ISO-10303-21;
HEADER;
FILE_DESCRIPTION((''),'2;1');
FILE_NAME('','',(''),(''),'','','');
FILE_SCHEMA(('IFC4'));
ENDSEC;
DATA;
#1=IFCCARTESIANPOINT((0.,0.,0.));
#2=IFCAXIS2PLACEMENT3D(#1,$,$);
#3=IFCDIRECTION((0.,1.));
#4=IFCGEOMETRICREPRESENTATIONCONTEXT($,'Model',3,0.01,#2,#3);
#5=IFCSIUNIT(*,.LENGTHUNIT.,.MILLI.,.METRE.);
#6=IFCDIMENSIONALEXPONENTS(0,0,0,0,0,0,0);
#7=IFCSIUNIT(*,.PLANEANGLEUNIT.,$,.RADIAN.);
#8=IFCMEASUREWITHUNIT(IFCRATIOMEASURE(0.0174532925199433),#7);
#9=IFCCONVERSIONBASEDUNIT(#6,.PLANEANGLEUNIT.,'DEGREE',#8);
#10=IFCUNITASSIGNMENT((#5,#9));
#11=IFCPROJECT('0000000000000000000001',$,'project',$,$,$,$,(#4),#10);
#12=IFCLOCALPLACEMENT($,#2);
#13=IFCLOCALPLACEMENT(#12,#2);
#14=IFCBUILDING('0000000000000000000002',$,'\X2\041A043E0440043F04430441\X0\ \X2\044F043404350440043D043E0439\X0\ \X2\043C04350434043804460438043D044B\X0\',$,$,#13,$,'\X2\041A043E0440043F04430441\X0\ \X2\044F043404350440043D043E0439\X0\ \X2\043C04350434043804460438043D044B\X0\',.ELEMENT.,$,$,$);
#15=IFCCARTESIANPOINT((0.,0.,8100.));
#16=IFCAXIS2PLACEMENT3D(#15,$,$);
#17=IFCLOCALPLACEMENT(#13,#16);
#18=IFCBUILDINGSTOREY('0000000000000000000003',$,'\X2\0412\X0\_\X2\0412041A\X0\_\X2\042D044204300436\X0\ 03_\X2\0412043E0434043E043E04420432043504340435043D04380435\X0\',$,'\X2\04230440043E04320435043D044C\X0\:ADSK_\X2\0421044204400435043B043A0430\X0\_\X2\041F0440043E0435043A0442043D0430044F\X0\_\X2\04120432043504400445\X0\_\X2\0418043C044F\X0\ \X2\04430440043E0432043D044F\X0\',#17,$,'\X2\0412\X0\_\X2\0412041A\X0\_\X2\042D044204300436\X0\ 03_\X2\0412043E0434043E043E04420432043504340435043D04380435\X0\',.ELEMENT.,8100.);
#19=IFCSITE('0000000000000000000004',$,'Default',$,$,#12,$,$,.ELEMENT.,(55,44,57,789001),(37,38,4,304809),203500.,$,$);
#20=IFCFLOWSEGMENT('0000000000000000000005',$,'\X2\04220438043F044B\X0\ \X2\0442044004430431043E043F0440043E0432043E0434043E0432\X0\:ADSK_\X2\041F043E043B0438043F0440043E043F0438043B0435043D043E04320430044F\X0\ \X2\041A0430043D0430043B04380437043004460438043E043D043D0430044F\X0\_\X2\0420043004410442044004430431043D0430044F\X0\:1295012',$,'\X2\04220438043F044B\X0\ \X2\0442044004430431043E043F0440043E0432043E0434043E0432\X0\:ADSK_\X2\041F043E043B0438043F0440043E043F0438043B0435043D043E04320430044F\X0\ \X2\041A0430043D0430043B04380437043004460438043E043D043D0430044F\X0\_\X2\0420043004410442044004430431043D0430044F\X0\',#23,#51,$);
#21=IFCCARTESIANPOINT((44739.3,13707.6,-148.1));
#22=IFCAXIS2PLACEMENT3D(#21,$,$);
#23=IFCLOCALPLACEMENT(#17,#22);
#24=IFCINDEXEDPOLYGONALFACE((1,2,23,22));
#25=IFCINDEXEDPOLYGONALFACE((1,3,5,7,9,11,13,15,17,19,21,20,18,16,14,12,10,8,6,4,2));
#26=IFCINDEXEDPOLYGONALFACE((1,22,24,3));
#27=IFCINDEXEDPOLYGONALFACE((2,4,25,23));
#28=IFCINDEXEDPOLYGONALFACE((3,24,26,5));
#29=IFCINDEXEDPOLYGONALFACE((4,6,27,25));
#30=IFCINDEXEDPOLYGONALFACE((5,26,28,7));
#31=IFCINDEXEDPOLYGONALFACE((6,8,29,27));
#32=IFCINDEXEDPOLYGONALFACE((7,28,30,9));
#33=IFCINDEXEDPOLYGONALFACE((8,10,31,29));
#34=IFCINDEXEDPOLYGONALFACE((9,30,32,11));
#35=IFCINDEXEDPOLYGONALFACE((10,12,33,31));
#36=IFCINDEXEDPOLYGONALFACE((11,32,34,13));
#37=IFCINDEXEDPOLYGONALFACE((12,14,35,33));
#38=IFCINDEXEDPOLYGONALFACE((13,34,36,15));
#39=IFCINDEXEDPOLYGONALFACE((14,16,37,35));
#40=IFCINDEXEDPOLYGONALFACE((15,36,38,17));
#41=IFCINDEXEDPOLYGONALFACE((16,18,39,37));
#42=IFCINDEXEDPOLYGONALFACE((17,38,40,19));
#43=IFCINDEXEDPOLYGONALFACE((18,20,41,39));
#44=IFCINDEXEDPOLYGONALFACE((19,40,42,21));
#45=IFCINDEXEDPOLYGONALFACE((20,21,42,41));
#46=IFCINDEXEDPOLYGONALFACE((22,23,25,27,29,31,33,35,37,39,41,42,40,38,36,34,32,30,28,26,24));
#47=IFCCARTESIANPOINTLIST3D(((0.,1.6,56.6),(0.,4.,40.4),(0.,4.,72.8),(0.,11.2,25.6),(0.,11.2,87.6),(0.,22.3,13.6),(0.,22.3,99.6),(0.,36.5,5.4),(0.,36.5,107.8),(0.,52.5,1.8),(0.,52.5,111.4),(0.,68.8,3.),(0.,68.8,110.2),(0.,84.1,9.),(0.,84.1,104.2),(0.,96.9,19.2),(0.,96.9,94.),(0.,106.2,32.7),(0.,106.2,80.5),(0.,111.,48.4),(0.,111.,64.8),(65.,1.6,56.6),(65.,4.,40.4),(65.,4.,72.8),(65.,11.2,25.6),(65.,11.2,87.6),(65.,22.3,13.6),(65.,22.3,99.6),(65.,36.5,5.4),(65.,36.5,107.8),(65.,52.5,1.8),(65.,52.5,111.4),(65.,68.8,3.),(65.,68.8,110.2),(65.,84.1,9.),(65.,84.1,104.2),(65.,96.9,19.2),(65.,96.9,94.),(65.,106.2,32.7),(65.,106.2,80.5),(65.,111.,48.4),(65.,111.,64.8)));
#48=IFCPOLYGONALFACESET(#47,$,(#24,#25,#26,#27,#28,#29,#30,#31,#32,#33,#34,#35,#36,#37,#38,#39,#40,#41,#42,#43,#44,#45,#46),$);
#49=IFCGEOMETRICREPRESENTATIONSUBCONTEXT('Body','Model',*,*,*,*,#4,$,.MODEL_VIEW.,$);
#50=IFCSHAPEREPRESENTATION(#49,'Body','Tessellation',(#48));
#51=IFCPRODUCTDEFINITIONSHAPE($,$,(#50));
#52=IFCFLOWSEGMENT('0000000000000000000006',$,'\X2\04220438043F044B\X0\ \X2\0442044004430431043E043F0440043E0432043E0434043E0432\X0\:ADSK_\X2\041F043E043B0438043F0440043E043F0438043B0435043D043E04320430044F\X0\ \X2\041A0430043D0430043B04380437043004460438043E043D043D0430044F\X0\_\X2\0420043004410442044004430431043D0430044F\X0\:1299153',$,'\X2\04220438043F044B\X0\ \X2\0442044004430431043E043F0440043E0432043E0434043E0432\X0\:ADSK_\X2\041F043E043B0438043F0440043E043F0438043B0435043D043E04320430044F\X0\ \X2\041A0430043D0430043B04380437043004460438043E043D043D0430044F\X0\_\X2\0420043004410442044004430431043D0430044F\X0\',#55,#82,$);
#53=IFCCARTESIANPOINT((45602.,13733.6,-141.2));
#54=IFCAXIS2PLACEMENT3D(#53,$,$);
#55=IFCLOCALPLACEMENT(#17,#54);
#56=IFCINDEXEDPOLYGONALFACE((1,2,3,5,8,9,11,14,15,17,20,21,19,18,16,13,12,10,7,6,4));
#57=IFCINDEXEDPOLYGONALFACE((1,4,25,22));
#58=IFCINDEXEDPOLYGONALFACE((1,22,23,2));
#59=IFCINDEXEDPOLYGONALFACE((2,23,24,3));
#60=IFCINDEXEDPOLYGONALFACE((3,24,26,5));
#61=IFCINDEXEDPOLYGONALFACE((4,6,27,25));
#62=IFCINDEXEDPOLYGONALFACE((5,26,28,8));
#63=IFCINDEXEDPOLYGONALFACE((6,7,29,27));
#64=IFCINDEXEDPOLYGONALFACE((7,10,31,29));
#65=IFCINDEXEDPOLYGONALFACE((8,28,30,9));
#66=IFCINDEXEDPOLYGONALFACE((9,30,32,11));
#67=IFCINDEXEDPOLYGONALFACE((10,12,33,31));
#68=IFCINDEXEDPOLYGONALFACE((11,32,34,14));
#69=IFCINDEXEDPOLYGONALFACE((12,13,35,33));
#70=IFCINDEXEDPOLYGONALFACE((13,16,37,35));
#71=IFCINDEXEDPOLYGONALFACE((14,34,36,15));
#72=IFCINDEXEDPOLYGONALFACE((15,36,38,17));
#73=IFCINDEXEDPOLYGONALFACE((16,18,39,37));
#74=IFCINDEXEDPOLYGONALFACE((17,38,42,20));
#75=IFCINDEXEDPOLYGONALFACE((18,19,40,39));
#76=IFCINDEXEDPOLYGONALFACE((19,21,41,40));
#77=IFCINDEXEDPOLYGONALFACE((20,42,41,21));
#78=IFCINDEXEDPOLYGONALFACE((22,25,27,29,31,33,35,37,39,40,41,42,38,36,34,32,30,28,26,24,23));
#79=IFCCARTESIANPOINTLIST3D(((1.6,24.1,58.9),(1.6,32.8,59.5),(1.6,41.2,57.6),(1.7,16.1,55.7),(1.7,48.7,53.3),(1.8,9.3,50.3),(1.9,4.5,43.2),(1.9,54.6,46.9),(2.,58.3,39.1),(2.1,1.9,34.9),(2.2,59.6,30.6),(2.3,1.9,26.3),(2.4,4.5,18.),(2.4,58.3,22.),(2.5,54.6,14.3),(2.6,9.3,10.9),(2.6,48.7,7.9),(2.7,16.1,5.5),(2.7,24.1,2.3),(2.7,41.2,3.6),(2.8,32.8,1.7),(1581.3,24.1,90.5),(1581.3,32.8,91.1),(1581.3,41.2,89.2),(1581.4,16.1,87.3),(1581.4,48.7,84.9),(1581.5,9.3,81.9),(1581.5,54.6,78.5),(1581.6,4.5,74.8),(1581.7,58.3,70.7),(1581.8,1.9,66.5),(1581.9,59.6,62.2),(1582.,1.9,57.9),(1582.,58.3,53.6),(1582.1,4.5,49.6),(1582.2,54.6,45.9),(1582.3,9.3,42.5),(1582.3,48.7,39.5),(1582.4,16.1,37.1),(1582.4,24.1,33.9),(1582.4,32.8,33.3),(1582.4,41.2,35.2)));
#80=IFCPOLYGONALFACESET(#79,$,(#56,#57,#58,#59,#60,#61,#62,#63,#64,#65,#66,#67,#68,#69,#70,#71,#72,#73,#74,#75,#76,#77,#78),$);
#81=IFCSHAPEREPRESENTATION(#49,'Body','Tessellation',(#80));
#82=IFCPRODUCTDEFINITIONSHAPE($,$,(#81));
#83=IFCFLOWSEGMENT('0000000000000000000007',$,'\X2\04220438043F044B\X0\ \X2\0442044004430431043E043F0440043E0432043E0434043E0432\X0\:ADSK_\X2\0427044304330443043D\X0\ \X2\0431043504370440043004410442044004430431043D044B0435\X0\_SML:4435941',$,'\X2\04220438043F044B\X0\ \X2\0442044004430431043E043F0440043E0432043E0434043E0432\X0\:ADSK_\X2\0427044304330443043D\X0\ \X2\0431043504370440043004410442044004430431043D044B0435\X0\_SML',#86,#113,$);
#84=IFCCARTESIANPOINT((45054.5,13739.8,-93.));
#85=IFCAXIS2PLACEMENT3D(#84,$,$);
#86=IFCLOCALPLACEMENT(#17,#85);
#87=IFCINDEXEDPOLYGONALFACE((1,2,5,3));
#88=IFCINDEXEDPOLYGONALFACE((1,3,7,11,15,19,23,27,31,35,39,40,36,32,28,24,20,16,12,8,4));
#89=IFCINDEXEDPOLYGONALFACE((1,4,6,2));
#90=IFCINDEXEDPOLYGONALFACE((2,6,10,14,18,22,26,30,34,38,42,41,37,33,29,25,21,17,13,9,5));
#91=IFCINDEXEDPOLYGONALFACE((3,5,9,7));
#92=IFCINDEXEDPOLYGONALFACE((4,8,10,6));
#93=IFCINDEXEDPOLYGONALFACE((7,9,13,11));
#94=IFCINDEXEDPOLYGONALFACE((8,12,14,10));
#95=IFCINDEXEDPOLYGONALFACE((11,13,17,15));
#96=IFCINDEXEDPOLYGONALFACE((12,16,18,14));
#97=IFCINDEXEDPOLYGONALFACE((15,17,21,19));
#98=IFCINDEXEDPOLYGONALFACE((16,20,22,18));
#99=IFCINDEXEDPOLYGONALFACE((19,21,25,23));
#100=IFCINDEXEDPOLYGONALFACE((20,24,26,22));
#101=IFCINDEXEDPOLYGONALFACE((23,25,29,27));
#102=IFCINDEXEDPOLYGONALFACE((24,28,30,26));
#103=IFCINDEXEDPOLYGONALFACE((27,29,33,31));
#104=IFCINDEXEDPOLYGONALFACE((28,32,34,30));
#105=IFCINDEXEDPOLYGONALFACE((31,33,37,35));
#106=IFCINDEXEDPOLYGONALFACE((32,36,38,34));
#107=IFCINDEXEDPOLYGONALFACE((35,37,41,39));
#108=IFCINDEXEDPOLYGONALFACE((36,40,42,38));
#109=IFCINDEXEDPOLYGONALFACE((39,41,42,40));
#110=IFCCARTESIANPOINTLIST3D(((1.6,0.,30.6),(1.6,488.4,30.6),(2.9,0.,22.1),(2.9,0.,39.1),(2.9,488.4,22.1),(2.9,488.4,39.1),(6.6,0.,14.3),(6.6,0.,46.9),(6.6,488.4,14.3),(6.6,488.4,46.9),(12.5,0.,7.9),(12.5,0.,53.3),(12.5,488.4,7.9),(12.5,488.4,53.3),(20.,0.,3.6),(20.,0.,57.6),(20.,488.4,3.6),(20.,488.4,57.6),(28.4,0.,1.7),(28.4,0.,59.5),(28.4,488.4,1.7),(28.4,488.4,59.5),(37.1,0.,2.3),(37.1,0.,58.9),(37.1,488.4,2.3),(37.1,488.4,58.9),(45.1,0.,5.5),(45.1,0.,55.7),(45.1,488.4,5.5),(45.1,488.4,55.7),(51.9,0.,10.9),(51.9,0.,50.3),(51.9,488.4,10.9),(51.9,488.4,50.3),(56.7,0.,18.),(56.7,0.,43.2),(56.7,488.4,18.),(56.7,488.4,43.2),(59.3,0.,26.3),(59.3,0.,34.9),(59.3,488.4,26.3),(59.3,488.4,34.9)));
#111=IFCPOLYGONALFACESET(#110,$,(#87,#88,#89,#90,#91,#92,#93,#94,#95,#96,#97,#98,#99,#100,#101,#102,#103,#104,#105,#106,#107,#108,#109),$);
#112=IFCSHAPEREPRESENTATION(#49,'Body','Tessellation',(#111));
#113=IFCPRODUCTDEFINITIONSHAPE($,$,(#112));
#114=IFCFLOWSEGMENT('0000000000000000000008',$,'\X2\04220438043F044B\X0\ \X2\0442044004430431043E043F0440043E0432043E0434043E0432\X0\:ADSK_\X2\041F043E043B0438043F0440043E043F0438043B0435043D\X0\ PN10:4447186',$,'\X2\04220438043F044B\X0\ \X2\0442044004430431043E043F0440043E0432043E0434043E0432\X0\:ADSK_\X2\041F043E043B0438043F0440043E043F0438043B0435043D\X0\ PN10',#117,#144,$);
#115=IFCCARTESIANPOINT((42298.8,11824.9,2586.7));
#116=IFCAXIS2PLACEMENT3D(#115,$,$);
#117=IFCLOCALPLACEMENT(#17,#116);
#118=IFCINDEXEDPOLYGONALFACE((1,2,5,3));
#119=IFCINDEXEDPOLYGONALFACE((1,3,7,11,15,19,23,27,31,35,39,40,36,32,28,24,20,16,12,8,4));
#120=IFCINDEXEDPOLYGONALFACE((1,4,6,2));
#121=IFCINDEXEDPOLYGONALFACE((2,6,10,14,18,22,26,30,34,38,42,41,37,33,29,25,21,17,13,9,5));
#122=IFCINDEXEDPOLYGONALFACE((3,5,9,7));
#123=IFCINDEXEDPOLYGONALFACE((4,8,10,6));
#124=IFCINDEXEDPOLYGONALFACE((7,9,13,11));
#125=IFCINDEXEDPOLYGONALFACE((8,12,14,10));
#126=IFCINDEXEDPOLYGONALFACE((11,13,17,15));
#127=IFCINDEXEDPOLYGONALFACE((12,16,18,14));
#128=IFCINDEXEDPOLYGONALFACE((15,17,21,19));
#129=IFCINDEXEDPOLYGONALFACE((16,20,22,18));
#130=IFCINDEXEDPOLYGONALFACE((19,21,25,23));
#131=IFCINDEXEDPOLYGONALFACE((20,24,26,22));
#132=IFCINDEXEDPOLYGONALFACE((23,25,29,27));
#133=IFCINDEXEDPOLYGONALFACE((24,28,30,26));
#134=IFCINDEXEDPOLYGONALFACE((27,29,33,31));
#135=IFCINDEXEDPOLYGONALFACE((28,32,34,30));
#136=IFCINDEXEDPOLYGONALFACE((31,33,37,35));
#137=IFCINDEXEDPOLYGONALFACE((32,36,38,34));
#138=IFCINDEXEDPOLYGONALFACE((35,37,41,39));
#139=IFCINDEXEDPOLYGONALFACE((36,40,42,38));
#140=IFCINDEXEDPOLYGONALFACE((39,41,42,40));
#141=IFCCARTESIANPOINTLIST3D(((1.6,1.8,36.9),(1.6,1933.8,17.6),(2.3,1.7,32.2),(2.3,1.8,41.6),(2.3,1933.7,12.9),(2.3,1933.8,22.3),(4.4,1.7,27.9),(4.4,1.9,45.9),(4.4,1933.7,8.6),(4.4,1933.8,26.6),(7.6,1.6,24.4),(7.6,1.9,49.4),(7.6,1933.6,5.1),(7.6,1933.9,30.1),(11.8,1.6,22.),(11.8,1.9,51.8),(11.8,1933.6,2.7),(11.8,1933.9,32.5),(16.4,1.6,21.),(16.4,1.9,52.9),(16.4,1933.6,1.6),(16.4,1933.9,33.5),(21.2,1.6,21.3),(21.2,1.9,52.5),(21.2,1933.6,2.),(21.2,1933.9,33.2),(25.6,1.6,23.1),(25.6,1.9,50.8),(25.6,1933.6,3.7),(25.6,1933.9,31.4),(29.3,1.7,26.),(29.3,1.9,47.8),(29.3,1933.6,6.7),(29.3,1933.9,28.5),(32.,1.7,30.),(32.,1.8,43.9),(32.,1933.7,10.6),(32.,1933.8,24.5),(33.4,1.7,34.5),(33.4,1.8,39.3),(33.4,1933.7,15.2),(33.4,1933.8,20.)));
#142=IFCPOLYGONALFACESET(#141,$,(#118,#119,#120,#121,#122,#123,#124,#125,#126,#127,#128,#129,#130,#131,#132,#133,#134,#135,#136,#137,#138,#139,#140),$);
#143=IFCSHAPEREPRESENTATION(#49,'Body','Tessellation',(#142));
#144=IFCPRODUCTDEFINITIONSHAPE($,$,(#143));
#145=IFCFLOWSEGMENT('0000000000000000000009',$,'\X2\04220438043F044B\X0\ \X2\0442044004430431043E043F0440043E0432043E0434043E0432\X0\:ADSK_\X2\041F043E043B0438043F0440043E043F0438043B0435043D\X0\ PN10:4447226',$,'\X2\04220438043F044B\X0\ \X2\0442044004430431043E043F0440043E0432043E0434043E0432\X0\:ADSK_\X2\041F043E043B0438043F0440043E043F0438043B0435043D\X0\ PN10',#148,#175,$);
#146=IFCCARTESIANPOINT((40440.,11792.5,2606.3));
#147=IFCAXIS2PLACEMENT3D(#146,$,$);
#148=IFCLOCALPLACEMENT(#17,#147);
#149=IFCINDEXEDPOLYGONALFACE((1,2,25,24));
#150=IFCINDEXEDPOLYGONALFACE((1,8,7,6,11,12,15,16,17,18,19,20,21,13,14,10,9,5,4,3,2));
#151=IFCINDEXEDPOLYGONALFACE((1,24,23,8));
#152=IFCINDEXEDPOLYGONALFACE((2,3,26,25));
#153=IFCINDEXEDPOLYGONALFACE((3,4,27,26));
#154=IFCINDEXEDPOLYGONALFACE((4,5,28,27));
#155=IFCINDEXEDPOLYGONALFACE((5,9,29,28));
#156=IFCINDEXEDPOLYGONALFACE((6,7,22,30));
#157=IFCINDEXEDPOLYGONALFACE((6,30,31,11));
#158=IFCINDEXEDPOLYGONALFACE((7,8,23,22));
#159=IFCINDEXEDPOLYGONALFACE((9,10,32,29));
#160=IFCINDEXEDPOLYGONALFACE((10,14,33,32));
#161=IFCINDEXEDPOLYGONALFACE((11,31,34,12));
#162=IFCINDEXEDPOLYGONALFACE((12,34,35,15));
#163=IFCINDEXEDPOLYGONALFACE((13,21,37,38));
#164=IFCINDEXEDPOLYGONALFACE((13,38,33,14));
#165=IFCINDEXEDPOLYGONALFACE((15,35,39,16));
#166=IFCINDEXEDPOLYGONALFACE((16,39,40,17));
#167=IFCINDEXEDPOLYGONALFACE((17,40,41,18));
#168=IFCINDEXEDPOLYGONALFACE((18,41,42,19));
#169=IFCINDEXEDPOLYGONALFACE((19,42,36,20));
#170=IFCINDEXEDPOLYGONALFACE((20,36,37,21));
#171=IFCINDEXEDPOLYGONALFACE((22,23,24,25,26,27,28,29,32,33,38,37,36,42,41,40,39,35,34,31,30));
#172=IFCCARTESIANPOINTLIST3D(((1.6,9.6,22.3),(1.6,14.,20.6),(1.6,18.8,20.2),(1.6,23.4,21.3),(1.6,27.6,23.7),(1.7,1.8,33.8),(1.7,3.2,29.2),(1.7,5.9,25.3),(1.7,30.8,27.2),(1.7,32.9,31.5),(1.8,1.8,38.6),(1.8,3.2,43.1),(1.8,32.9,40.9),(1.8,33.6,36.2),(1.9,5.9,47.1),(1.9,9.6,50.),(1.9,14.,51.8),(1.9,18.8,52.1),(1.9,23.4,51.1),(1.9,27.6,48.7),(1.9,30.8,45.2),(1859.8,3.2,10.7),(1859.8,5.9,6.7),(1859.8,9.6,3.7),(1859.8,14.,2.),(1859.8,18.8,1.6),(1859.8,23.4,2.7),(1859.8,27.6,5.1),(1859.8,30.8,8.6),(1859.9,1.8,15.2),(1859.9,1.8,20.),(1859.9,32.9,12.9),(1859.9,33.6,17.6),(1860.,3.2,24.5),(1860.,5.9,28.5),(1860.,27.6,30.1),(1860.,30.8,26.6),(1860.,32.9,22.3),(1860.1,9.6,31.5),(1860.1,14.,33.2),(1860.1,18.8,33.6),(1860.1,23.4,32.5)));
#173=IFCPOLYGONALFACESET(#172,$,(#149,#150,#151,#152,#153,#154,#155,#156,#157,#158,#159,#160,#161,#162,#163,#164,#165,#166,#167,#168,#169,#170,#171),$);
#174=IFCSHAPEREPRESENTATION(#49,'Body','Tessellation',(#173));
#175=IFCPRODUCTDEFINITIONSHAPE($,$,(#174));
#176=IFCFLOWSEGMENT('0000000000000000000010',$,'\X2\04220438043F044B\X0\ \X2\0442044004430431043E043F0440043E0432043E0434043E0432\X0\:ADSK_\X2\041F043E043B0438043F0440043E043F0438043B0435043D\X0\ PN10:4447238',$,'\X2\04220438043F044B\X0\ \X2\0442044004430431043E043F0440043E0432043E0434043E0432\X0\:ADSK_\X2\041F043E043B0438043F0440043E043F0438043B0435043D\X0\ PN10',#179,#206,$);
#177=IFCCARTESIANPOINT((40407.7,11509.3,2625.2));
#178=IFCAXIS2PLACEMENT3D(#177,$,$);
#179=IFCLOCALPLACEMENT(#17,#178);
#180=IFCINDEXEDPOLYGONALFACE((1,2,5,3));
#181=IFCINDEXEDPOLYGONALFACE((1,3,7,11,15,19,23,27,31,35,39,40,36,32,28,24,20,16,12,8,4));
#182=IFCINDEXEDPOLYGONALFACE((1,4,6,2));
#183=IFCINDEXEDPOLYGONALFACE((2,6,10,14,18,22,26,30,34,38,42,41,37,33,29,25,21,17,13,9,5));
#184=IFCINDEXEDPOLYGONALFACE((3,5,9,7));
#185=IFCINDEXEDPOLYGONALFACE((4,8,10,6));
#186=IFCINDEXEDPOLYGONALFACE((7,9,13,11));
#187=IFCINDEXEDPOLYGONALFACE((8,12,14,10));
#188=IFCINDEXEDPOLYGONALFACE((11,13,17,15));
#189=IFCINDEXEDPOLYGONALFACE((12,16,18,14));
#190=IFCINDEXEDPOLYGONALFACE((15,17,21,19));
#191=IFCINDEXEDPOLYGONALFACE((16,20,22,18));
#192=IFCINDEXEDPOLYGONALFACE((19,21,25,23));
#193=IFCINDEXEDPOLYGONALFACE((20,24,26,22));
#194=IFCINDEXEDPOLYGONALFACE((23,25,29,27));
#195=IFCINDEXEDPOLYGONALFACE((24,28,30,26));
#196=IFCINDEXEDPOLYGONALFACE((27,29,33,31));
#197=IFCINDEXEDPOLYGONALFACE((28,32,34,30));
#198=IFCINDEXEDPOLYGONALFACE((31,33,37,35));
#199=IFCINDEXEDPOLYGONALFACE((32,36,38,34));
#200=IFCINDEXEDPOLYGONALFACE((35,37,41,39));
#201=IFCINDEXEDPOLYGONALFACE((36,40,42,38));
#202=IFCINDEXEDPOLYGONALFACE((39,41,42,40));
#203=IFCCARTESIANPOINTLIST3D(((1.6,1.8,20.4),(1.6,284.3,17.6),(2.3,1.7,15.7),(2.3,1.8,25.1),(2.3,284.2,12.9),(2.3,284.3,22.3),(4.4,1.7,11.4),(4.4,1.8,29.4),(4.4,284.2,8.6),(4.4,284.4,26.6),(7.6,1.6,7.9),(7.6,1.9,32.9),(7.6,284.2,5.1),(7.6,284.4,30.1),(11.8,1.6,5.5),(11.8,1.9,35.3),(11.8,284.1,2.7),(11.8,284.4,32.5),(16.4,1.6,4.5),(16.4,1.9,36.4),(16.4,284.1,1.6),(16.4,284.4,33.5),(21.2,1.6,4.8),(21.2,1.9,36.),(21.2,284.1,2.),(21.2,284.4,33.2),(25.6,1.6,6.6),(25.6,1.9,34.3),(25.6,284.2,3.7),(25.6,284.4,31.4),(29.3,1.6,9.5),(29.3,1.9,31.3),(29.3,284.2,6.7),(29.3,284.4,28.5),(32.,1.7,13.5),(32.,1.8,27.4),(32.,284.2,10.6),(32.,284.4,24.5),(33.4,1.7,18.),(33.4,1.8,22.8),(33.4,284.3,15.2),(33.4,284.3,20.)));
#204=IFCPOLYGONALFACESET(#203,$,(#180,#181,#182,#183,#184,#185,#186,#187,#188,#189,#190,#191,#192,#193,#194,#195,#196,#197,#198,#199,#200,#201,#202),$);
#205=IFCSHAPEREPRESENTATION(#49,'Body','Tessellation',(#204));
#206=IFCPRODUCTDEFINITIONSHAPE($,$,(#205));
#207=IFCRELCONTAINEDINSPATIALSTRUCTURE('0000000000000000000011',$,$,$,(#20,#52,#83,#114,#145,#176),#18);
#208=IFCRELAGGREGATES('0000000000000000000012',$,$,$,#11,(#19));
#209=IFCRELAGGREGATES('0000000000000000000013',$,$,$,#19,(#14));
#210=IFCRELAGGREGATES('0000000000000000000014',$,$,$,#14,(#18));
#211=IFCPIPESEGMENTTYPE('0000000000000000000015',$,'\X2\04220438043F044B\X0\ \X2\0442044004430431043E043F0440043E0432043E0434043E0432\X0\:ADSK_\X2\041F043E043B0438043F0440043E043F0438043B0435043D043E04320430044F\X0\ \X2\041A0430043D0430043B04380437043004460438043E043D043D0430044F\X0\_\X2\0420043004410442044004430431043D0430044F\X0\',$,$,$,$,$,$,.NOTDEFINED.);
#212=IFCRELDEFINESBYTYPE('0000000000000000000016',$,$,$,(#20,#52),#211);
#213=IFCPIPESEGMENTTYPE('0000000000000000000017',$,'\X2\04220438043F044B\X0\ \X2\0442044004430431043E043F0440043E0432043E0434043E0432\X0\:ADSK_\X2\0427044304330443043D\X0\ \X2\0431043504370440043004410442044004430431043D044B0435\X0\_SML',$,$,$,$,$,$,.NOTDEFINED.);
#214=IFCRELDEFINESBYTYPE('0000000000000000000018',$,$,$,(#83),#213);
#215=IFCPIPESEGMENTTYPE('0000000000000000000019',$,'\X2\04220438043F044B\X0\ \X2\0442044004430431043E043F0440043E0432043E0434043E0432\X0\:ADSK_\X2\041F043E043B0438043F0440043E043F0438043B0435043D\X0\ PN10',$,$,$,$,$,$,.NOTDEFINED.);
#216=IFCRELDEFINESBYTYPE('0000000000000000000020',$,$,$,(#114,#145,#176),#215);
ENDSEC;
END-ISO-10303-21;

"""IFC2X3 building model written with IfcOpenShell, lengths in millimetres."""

from ifc_helpers import new_model, entity, si_unit, converted_unit, direction, frame, origin, origin_2d_with_axis, place, context, subcontext, project, spatial, circle, extrude, type_object, element, save


model = new_model("IFC2X3")

# Units and contexts
model_context = context("Model", 3, precision=0.01, world=origin(), true_north=direction((0.0, 1.0)))
body_context = subcontext(model_context, "Body", "Model", "MODEL_VIEW")
ifc_project = project(units=[si_unit("LENGTHUNIT", "METRE", prefix="MILLI"), converted_unit("PLANEANGLEUNIT", "DEGREE", entity("IfcRatioMeasure", 0.0174532925199433), si_unit("PLANEANGLEUNIT", "RADIAN"), dimensions=[0, 0, 0, 0, 0, 0, 0])], contexts=[model_context])

# Site, building, storey
site_placement = place(None, origin())
site = spatial("IfcSite", under=ifc_project, at=site_placement, Name="Default", CompositionType="ELEMENT", RefLatitude=(55, 44, 57, 789001), RefLongitude=(37, 38, 4, 304809), RefElevation=203500.0)
building_placement = place(site_placement, origin())
building = spatial("IfcBuilding", under=site, at=building_placement, Name="Корпус ядерной медицины", LongName="Корпус ядерной медицины", CompositionType="ELEMENT")
storey_placement = place(building_placement, frame((0.0, 0.0, 8100.0)))
storey = spatial("IfcBuildingStorey", under=building, at=storey_placement, Name="В_ВК_Этаж 03_Водоотведение", ObjectType="Уровень:ADSK_Стрелка_Проектная_Вверх_Имя уровня", LongName="В_ВК_Этаж 03_Водоотведение", CompositionType="ELEMENT", Elevation=8100.0)

# Flow segments
pipe_segment_type_1 = type_object("IfcPipeSegmentType", Name="Типы трубопроводов:ADSK_Полипропиленовая Канализационная_Раструбная", PredefinedType="NOTDEFINED")
flow_segment_1_placement = place(storey_placement, frame((44739.3, 13707.6, -148.1)))
element("IfcFlowSegment", 1, at=flow_segment_1_placement, inside=storey, type_object=pipe_segment_type_1, Name="Типы трубопроводов:ADSK_Полипропиленовая Канализационная_Раструбная:1295012", ObjectType="Типы трубопроводов:ADSK_Полипропиленовая Канализационная_Раструбная", context=body_context, shape_type="SweptSolid", body=[
    extrude(circle(Radius=55.0, at=origin_2d_with_axis()), frame((0.0, 56.6, 56.6), z_axis=(1.0, 0.0, 0.0), x_axis=(0.0, -1.0, 0.0)), (0.0, 0.0, 1.0), 65.0),
])
flow_segment_2_placement = place(storey_placement, frame((45602.0, 13733.6, -141.2)))
element("IfcFlowSegment", 2, at=flow_segment_2_placement, inside=storey, type_object=pipe_segment_type_1, Name="Типы трубопроводов:ADSK_Полипропиленовая Канализационная_Раструбная:1299153", ObjectType="Типы трубопроводов:ADSK_Полипропиленовая Канализационная_Раструбная", context=body_context, shape_type="SweptSolid", body=[
    extrude(circle(Radius=29.0, at=origin_2d_with_axis()), frame((2.2, 30.6, 30.6), z_axis=(0.9998, 0.0, 0.019996), x_axis=(0.0, 1.0, 0.0)), (0.0, 0.0, 1.0), 1580.0),
])
pipe_segment_type_2 = type_object("IfcPipeSegmentType", Name="Типы трубопроводов:ADSK_Чугун безраструбные_SML", PredefinedType="NOTDEFINED")
flow_segment_3_placement = place(storey_placement, frame((45054.5, 13739.8, -93.0)))
element("IfcFlowSegment", 3, at=flow_segment_3_placement, inside=storey, type_object=pipe_segment_type_2, Name="Типы трубопроводов:ADSK_Чугун безраструбные_SML:4435941", ObjectType="Типы трубопроводов:ADSK_Чугун безраструбные_SML", context=body_context, shape_type="SweptSolid", body=[
    extrude(circle(Radius=29.0, at=origin_2d_with_axis()), frame((30.6, 0.0, 30.6), z_axis=(0.0, 1.0, 0.0), x_axis=(-1.0, 0.0, 0.0)), (0.0, 0.0, 1.0), 488.4),
])
pipe_segment_type_3 = type_object("IfcPipeSegmentType", Name="Типы трубопроводов:ADSK_Полипропилен PN10", PredefinedType="NOTDEFINED")
flow_segment_4_placement = place(storey_placement, frame((42298.8, 11824.9, 2586.7)))
element("IfcFlowSegment", 4, at=flow_segment_4_placement, inside=storey, type_object=pipe_segment_type_3, Name="Типы трубопроводов:ADSK_Полипропилен PN10:4447186", ObjectType="Типы трубопроводов:ADSK_Полипропилен PN10", context=body_context, shape_type="SweptSolid", body=[
    extrude(circle(Radius=16.0, at=origin_2d_with_axis()), frame((17.6, 1.8, 36.9), z_axis=(0.0, 0.99995, -0.01), x_axis=(-1.0, 0.0, 0.0)), (0.0, 0.0, 1.0), 1932.1),
])
flow_segment_5_placement = place(storey_placement, frame((40440.0, 11792.5, 2606.3)))
element("IfcFlowSegment", 5, at=flow_segment_5_placement, inside=storey, type_object=pipe_segment_type_3, Name="Типы трубопроводов:ADSK_Полипропилен PN10:4447226", ObjectType="Типы трубопроводов:ADSK_Полипропилен PN10", context=body_context, shape_type="SweptSolid", body=[
    extrude(circle(Radius=16.0, at=origin_2d_with_axis()), frame((1.8, 17.6, 36.2), z_axis=(0.99995, 0.0, -0.01), x_axis=(0.0, 1.0, 0.0)), (0.0, 0.0, 1.0), 1858.2),
])
flow_segment_6_placement = place(storey_placement, frame((40407.7, 11509.3, 2625.2)))
element("IfcFlowSegment", 6, at=flow_segment_6_placement, inside=storey, type_object=pipe_segment_type_3, Name="Типы трубопроводов:ADSK_Полипропилен PN10:4447238", ObjectType="Типы трубопроводов:ADSK_Полипропилен PN10", context=body_context, shape_type="SweptSolid", body=[
    extrude(circle(Radius=16.0, at=origin_2d_with_axis()), frame((17.6, 284.3, 17.6), z_axis=(0.0, -0.99995, 0.01), x_axis=(-1.0, 0.0, 0.0)), (0.0, 0.0, 1.0), 282.5),
])

save(model, "model.ifc")
